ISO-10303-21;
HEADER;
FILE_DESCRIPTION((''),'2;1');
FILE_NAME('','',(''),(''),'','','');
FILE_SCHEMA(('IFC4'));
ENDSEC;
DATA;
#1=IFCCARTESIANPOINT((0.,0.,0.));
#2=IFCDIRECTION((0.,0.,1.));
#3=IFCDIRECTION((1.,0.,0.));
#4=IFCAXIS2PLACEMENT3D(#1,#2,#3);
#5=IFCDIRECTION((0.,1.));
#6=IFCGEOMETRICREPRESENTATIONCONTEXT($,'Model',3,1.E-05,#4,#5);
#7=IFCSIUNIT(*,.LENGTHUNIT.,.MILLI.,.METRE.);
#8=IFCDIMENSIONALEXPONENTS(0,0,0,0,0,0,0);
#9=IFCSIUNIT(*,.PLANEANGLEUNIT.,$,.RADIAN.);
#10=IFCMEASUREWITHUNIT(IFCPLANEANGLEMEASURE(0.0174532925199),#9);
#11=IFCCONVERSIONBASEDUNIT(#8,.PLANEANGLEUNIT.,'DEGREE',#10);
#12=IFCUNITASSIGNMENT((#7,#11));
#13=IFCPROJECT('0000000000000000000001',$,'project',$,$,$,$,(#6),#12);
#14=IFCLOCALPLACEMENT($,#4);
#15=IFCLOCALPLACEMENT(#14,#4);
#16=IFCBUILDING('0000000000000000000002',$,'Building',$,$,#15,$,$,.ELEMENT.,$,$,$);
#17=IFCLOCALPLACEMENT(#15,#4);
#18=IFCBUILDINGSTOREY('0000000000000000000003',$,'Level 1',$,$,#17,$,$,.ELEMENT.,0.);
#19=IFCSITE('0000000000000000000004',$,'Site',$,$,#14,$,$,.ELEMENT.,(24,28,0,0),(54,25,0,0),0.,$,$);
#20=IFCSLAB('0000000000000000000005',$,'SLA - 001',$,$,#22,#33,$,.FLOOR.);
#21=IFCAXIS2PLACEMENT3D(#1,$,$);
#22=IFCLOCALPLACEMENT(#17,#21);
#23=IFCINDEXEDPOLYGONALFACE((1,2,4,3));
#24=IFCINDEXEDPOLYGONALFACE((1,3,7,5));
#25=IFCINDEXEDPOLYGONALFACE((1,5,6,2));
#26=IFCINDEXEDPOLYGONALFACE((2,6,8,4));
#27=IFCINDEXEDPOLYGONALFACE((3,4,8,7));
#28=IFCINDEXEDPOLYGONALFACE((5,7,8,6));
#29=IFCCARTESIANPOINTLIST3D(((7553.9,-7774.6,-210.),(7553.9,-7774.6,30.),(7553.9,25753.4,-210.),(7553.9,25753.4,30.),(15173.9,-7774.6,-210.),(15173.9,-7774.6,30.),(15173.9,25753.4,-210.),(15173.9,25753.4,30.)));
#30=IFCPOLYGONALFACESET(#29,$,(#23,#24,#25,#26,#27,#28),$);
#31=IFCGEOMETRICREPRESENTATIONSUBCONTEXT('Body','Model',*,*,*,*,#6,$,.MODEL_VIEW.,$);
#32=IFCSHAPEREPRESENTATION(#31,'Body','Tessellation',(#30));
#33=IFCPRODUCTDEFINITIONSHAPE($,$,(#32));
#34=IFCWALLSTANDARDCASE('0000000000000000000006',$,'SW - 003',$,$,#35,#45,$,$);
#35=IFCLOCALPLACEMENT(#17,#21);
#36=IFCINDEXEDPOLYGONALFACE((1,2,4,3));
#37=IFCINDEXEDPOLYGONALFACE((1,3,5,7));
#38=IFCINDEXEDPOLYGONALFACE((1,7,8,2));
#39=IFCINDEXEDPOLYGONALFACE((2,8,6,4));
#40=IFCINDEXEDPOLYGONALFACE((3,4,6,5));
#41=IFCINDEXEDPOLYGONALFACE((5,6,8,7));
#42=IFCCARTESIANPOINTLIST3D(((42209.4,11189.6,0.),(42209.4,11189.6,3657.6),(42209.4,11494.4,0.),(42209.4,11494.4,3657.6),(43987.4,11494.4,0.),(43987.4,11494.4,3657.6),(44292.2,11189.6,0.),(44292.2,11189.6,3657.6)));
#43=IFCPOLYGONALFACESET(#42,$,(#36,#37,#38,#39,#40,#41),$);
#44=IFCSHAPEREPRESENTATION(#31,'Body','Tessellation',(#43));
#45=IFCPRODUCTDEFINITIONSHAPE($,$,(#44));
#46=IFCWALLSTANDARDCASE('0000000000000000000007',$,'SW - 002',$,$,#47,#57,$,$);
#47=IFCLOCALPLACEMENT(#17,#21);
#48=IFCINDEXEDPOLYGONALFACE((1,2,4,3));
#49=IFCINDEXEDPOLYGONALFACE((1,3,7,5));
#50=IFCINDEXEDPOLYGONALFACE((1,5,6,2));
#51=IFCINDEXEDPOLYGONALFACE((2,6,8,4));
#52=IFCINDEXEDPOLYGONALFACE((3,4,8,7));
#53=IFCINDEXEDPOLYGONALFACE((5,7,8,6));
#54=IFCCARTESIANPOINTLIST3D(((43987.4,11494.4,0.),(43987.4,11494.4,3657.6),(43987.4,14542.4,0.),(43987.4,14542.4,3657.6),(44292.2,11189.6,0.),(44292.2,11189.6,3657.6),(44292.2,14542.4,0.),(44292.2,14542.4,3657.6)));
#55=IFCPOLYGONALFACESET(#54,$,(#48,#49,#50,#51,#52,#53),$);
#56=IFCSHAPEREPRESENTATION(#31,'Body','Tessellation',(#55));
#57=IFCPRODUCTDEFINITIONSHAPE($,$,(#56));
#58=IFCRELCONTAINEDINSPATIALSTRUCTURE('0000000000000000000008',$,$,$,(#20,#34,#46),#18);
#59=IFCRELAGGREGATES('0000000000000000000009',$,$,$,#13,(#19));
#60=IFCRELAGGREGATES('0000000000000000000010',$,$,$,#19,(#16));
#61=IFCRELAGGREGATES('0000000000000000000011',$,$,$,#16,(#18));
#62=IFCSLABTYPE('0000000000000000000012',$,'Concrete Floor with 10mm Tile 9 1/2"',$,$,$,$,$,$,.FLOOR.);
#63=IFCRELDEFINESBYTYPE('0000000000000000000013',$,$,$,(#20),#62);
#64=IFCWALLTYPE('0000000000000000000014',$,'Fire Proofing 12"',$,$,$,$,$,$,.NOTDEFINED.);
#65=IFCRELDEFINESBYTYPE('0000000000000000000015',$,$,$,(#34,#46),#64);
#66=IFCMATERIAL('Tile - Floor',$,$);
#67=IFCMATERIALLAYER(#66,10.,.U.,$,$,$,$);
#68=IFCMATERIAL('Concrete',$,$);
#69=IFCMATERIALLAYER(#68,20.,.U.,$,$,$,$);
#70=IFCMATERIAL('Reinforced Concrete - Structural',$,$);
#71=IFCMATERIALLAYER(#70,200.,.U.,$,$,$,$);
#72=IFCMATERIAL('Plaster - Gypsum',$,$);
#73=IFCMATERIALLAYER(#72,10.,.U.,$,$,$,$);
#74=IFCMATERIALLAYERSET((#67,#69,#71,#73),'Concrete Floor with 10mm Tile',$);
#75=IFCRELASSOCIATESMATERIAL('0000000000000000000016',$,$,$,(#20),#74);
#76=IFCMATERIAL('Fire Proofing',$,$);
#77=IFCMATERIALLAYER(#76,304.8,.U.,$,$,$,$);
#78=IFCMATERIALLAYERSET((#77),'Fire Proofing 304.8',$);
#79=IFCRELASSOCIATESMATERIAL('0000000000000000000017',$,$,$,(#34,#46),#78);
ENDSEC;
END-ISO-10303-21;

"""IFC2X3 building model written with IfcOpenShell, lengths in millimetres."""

from ifc_helpers import new_model, entity, si_unit, converted_unit, direction, frame, origin_with_axes, place, context, subcontext, project, spatial, polyline, outline, extrude, material, layer, layer_set, layer_usage, type_object, element, save


model = new_model("IFC2X3")

# Units and contexts
model_context = context("Model", 3, precision=1e-05, world=origin_with_axes(), true_north=direction((0.0, 1.0)))
body_context = subcontext(model_context, "Body", "Model", "MODEL_VIEW")
ifc_project = project(units=[si_unit("LENGTHUNIT", "METRE", prefix="MILLI"), converted_unit("PLANEANGLEUNIT", "DEGREE", entity("IfcPlaneAngleMeasure", 0.0174532925199), si_unit("PLANEANGLEUNIT", "RADIAN"), dimensions=[0, 0, 0, 0, 0, 0, 0])], contexts=[model_context])

# Site, building, storey
site_placement = place(None, origin_with_axes())
site = spatial("IfcSite", under=ifc_project, at=site_placement, Name="Site", CompositionType="ELEMENT", RefLatitude=(24, 28, 0, 0), RefLongitude=(54, 25, 0, 0), RefElevation=0.0)
building_placement = place(site_placement, origin_with_axes())
building = spatial("IfcBuilding", under=site, at=building_placement, Name="Building", CompositionType="ELEMENT")
storey_placement = place(building_placement, origin_with_axes())
storey = spatial("IfcBuildingStorey", under=building, at=storey_placement, Name="Level 1", CompositionType="ELEMENT", Elevation=0.0)

# Slab
ifc_material_1 = material(Name="Tile - Floor")
ifc_layer_1 = layer(ifc_material_1, 10.0, ventilated="UNKNOWN")
ifc_material_2 = material(Name="Concrete")
ifc_layer_2 = layer(ifc_material_2, 20.0, ventilated="UNKNOWN")
ifc_material_3 = material(Name="Reinforced Concrete - Structural")
ifc_layer_3 = layer(ifc_material_3, 200.0, ventilated="UNKNOWN")
ifc_material_4 = material(Name="Plaster - Gypsum")
ifc_layer_4 = layer(ifc_material_4, 10.0, ventilated="UNKNOWN")
ifc_layer_set_1 = layer_set([ifc_layer_1, ifc_layer_2, ifc_layer_3, ifc_layer_4], Name="Concrete Floor with 10mm Tile")
ifc_layer_usage_1 = layer_usage(ifc_layer_set_1, "AXIS3", "NEGATIVE", 240.0)
slab_type = type_object("IfcSlabType", Name="Concrete Floor with 10mm Tile 9 1/2\"", PredefinedType="FLOOR")
slab_placement = place(storey_placement, frame((15173.9, 25753.4, 0.0), z_axis=(0.0, 0.0, 1.0), x_axis=(1.0, 0.0, 0.0)))
element("IfcSlab", 1, at=slab_placement, inside=storey, type_object=slab_type, material=ifc_layer_usage_1, Name="SLA - 001", PredefinedType="FLOOR", context=body_context, shape_type="SweptSolid", body=[
    extrude(outline(polyline([(0.0, 0.0), (-7620.0, 0.0), (-7620.0, -33528.0), (0.0, -33528.0), (0.0, 0.0)])), frame((0.0, 0.0, -210.0), z_axis=(0.0, 0.0, 1.0), x_axis=(1.0, 0.0, 0.0)), (0.0, 0.0, 1.0), 240.0),
])

# Walls
ifc_material_5 = material(Name="Fire Proofing")
ifc_layer_5 = layer(ifc_material_5, 304.8, ventilated="UNKNOWN")
ifc_layer_set_2 = layer_set([ifc_layer_5], Name="Fire Proofing 304.8")
ifc_layer_usage_2 = layer_usage(ifc_layer_set_2, "AXIS2", "NEGATIVE", 152.4)
wall_type = type_object("IfcWallType", Name="Fire Proofing 12\"", PredefinedType="NOTDEFINED")
wall_1_placement = place(storey_placement, frame((44139.8, 11342.0, 0.0), z_axis=(0.0, 0.0, 1.0), x_axis=(-1.0, 0.0, 0.0)))
element("IfcWallStandardCase", 2, at=wall_1_placement, inside=storey, type_object=wall_type, material=ifc_layer_usage_2, Name="SW - 003", context=body_context, shape_type="SweptSolid", body=[
    extrude(outline(polyline([(152.4, -152.4), (1930.4, -152.4), (1930.4, 152.4), (-152.4, 152.4), (152.4, -152.4)])), origin_with_axes(), (0.0, 0.0, 1.0), 3657.6),
])
ifc_layer_usage_3 = layer_usage(ifc_layer_set_2, "AXIS2", "NEGATIVE", 152.4)
wall_2_placement = place(storey_placement, frame((44139.8, 11342.0, 0.0), z_axis=(0.0, 0.0, 1.0), x_axis=(0.0, 1.0, 0.0)))
element("IfcWallStandardCase", 3, at=wall_2_placement, inside=storey, type_object=wall_type, material=ifc_layer_usage_3, Name="SW - 002", context=body_context, shape_type="SweptSolid", body=[
    extrude(outline(polyline([(-152.4, -152.4), (3200.4, -152.4), (3200.4, 152.4), (152.4, 152.4), (-152.4, -152.4)])), origin_with_axes(), (0.0, 0.0, 1.0), 3657.6),
])

save(model, "model.ifc")
